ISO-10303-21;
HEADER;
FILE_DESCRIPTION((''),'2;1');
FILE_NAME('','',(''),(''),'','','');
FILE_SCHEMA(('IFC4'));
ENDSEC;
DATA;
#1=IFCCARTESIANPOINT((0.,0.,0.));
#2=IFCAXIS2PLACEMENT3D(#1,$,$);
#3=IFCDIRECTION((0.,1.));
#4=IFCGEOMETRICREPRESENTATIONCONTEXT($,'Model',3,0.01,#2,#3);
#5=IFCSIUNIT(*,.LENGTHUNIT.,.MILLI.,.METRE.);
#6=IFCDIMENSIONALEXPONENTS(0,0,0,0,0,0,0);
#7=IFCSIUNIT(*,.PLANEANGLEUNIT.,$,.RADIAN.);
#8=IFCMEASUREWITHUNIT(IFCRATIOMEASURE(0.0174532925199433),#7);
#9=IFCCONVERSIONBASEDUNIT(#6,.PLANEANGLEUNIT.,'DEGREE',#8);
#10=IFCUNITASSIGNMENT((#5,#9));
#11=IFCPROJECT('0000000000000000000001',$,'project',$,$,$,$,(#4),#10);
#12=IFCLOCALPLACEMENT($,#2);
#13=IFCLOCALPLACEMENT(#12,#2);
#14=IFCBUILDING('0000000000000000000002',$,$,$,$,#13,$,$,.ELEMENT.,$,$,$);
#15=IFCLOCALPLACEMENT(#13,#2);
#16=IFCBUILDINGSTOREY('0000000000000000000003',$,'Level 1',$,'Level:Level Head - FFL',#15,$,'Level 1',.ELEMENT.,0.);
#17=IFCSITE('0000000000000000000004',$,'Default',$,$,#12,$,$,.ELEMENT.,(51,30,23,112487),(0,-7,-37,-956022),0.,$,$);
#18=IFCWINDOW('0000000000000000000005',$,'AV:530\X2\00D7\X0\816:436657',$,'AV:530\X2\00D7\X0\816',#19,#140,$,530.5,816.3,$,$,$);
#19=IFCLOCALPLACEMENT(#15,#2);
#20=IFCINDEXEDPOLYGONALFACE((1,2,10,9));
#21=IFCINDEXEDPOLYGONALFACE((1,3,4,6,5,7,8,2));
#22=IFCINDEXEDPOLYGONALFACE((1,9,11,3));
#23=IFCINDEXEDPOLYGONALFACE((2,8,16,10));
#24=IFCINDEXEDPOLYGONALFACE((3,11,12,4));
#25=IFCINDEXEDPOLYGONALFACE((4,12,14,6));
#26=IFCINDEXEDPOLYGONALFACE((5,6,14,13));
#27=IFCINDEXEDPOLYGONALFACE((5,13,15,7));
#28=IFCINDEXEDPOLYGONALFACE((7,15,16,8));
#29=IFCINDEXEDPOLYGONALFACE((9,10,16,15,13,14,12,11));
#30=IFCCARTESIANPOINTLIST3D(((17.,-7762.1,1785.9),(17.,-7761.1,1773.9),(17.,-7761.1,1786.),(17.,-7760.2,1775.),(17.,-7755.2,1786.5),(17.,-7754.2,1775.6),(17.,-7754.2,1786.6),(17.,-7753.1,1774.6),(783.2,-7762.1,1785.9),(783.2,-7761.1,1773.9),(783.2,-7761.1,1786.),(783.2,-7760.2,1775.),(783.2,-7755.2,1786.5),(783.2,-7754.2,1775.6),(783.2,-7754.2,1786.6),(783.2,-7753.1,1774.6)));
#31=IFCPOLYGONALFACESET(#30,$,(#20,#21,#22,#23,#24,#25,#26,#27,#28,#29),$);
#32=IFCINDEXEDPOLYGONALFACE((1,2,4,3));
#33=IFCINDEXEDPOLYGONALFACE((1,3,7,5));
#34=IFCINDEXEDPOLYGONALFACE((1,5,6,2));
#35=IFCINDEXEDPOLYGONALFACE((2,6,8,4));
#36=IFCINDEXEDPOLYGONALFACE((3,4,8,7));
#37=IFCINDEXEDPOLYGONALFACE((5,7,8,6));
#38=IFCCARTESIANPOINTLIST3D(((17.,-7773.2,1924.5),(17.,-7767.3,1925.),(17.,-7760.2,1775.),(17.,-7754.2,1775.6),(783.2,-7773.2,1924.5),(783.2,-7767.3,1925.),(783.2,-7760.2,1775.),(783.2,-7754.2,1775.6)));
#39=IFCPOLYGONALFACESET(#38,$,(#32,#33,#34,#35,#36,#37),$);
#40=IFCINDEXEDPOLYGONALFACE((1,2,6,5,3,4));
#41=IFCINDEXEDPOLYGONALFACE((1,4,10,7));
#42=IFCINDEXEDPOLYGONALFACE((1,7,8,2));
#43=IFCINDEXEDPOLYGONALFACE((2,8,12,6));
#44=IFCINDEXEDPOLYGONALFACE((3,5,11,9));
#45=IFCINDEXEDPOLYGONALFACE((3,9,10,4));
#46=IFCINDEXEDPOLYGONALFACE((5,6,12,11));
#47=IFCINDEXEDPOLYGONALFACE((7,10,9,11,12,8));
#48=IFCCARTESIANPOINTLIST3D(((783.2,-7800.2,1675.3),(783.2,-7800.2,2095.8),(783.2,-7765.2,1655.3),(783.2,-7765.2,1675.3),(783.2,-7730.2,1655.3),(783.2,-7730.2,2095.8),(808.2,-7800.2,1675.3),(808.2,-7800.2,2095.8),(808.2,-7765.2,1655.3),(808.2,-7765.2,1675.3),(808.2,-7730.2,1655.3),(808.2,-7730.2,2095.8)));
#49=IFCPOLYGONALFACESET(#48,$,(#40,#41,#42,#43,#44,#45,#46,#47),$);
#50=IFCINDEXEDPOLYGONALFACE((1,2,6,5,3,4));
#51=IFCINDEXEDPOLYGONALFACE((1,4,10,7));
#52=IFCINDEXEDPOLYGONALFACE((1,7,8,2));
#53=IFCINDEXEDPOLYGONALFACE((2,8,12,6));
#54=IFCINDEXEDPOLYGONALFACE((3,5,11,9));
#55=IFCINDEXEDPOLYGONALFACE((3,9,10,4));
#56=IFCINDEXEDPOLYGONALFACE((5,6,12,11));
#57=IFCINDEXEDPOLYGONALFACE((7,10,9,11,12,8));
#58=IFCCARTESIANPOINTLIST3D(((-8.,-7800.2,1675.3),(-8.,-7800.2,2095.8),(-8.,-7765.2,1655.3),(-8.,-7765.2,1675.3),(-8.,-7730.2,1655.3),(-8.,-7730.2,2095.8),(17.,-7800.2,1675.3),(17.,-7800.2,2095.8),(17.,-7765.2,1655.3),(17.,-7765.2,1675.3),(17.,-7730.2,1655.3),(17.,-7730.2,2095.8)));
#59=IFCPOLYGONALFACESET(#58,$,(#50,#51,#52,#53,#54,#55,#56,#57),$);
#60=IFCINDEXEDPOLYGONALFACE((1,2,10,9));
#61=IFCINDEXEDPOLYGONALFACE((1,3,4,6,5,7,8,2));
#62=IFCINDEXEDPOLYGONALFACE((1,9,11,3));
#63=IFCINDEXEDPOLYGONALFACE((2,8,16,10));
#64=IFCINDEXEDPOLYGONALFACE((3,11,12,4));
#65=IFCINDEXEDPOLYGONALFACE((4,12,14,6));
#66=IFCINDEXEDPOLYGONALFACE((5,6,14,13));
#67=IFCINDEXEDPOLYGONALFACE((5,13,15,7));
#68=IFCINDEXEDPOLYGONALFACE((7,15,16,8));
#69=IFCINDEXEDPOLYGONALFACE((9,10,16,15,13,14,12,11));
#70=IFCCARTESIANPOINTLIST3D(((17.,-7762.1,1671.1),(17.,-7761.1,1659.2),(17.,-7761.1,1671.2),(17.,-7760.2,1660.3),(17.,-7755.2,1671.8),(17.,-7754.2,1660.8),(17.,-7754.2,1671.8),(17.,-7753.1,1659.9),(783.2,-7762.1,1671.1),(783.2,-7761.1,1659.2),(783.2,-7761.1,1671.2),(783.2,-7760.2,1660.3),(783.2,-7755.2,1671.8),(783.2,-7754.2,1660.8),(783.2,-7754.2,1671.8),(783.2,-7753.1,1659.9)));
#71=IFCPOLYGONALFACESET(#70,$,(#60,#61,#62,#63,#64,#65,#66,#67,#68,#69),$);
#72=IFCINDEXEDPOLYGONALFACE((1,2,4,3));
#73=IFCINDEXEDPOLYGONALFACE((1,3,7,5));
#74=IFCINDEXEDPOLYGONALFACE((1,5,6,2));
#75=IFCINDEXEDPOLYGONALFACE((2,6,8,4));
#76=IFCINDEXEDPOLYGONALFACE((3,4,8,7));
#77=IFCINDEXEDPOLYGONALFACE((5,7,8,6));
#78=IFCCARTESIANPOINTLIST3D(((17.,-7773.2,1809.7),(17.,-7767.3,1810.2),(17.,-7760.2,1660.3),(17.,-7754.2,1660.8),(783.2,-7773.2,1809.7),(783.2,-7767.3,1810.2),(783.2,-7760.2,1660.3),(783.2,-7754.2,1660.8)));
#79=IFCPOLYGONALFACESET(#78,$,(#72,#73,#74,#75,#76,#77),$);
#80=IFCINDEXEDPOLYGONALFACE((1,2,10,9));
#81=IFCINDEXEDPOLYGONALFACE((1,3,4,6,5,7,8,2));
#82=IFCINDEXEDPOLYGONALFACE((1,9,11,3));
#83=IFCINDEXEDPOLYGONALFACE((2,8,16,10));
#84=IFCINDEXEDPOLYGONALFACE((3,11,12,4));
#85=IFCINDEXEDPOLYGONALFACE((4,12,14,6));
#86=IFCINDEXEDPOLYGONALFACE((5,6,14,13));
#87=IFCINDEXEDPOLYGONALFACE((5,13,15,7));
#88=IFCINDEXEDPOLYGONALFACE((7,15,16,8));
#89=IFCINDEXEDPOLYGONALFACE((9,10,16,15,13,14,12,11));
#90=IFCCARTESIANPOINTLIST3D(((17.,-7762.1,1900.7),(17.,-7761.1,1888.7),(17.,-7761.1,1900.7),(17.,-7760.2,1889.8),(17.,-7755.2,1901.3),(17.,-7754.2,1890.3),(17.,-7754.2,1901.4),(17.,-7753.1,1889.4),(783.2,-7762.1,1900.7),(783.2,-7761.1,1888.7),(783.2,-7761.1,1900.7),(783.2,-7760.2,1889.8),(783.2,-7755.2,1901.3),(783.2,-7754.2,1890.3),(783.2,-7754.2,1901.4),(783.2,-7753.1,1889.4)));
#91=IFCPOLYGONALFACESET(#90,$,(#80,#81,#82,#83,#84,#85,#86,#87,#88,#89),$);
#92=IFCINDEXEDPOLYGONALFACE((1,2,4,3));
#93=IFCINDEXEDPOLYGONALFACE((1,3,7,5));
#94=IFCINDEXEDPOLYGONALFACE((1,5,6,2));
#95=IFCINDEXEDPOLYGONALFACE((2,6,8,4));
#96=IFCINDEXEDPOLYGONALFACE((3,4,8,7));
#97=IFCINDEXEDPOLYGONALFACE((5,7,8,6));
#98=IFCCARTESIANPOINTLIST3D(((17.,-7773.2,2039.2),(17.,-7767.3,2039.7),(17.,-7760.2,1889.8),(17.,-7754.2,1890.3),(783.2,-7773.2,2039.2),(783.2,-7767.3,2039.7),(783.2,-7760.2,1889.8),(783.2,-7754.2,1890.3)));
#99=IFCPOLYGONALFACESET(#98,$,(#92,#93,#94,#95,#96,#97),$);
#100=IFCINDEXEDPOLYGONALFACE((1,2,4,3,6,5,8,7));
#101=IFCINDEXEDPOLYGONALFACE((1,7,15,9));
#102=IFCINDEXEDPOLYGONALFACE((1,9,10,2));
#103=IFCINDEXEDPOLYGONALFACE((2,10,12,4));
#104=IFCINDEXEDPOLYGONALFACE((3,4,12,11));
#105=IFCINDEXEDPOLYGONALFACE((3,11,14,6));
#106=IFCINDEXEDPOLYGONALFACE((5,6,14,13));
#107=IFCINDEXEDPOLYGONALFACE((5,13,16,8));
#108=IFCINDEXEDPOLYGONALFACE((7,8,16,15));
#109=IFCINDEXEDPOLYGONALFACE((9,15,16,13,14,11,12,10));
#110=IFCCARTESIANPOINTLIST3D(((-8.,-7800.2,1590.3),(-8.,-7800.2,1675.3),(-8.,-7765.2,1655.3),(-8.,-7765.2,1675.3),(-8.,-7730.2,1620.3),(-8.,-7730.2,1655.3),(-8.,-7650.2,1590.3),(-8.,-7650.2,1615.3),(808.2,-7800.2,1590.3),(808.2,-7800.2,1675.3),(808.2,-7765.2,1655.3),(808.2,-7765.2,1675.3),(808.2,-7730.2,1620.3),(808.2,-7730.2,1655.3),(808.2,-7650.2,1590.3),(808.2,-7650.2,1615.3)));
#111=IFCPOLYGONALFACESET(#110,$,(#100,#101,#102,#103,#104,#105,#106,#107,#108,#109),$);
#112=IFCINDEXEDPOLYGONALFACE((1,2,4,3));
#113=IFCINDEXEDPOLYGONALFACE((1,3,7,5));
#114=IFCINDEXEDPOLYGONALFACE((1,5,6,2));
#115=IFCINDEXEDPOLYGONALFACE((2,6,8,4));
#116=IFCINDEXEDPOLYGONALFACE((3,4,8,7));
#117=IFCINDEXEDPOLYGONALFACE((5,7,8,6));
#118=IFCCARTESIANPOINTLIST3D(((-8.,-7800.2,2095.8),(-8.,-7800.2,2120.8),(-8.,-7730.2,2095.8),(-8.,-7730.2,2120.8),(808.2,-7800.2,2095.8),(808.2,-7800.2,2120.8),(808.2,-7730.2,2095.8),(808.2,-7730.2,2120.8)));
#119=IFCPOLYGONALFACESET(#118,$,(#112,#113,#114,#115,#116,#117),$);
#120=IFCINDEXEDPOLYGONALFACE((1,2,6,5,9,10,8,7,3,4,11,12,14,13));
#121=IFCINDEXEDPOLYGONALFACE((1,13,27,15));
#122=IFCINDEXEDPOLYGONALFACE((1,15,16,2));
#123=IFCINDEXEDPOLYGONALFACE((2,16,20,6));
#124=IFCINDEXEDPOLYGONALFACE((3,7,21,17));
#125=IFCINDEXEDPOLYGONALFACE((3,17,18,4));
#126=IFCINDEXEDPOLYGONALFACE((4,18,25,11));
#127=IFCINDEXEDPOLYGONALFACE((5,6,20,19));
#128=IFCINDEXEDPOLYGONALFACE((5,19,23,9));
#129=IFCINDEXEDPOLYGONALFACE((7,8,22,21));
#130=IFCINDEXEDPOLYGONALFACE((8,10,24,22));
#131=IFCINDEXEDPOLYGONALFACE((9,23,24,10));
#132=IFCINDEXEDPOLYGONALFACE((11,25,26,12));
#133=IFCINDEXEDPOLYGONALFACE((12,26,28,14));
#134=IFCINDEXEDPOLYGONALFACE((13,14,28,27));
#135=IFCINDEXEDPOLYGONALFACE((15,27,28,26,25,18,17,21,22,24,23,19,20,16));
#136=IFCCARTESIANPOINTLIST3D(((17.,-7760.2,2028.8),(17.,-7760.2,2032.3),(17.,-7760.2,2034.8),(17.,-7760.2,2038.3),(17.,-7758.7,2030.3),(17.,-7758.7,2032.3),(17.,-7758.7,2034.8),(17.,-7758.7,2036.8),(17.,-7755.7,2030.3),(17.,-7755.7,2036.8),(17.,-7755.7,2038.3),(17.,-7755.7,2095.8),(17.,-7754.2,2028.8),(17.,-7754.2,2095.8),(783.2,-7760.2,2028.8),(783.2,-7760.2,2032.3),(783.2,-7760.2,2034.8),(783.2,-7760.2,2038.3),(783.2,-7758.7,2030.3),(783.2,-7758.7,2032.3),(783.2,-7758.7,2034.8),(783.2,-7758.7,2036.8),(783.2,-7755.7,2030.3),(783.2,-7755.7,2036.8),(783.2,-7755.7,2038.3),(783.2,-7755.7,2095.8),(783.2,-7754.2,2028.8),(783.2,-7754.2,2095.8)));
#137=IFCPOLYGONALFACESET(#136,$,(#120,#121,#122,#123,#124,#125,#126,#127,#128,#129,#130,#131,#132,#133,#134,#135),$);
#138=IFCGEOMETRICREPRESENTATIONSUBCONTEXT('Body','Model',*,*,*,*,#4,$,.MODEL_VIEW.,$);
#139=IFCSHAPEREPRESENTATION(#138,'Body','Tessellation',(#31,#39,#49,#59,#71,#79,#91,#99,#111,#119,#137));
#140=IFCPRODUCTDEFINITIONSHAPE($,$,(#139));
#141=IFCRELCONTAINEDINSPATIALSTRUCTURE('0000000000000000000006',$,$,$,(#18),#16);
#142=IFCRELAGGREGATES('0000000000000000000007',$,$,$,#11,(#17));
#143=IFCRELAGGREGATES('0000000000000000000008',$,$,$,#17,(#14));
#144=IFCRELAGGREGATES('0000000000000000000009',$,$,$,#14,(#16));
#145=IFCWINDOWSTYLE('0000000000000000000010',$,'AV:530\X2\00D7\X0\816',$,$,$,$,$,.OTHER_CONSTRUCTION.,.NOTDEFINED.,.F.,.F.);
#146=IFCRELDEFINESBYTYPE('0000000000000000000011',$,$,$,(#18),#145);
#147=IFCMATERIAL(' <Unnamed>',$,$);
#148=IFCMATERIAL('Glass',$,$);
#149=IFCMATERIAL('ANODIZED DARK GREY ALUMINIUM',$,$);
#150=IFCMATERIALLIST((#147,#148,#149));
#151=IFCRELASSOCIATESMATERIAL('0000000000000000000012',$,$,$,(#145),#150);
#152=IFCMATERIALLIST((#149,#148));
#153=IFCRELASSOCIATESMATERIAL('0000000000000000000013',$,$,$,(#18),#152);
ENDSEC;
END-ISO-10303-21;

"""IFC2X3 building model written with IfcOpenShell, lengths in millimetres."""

from ifc_helpers import new_model, entity, si_unit, converted_unit, direction, frame, frame_2d, origin, origin_2d_with_axis, place, context, subcontext, project, spatial, polyline, rectangle, outline, extrude, source, transform, mapped, material, material_list, type_object, type_shapes, element, save


model = new_model("IFC2X3")

# Units and contexts
model_context = context("Model", 3, precision=0.01, world=origin(), true_north=direction((0.0, 1.0)))
body_context = subcontext(model_context, "Body", "Model", "MODEL_VIEW")
ifc_project = project(units=[si_unit("LENGTHUNIT", "METRE", prefix="MILLI"), converted_unit("PLANEANGLEUNIT", "DEGREE", entity("IfcRatioMeasure", 0.0174532925199433), si_unit("PLANEANGLEUNIT", "RADIAN"), dimensions=[0, 0, 0, 0, 0, 0, 0])], contexts=[model_context])

# Site, building, storey
site_placement = place(None, origin())
site = spatial("IfcSite", under=ifc_project, at=site_placement, Name="Default", CompositionType="ELEMENT", RefLatitude=(51, 30, 23, 112487), RefLongitude=(0, -7, -37, -956022), RefElevation=0.0)
building_placement = place(site_placement, origin())
building = spatial("IfcBuilding", under=site, at=building_placement, CompositionType="ELEMENT")
storey_placement = place(building_placement, origin())
storey = spatial("IfcBuildingStorey", under=building, at=storey_placement, Name="Level 1", ObjectType="Level:Level Head - FFL", LongName="Level 1", CompositionType="ELEMENT", Elevation=0.0)

# Window
ifc_material_1 = material(Name="Glass")
ifc_material_2 = material(Name="ANODIZED DARK GREY ALUMINIUM")
ifc_material_list_1 = material_list([ifc_material_2, ifc_material_1])
ifc_material_3 = material(Name=" <Unnamed>")
ifc_material_list_2 = material_list([ifc_material_3, ifc_material_1, ifc_material_2])
window_style_1 = type_object("IfcWindowStyle", Name="AV:530×816", ConstructionType="OTHER_CONSTRUCTION", OperationType="NOTDEFINED", ParameterTakesPrecedence=False, Sizeable=False, material=ifc_material_list_2)
shared_shape_1 = source(origin(), body_context, "Body", "SweptSolid", [
    extrude(outline(polyline([(-5.8, -3.0), (-5.8, -4.0), (6.3, -4.0), (6.3, 4.0), (-5.8, 4.0), (-5.8, 3.0), (5.2, 3.0), (5.2, -3.0), (-5.8, -3.0)])), frame((25.0, 42.5, 190.2), z_axis=(-1.0, 0.0, 0.0), x_axis=(0.0, 0.087156, -0.996195)), (0.0, 0.0, -1.0), 766.3),
    extrude(rectangle(XDim=150.0, YDim=6.0, at=frame_2d((0.0, 0.0), x_axis=(1.0, 0.0))), frame((25.0, 36.5, 259.7), z_axis=(1.0, 0.0, 0.0), x_axis=(0.0, 0.087156, -0.996195)), (0.0, 0.0, 1.0), 766.3),
    extrude(outline(polyline([(-287.0, -35.0), (133.5, -35.0), (133.5, 0.0), (153.5, 0.0), (153.5, 35.0), (-287.0, 35.0), (-287.0, -35.0)])), frame((791.3, 35.0, 218.5), z_axis=(1.0, 0.0, 0.0), x_axis=(0.0, 0.0, -1.0)), (0.0, 0.0, 1.0), 25.0),
    extrude(outline(polyline([(-287.0, -35.0), (133.5, -35.0), (133.5, 0.0), (153.5, 0.0), (153.5, 35.0), (-287.0, 35.0), (-287.0, -35.0)])), frame((0.0, 35.0, 218.5), z_axis=(1.0, 0.0, 0.0), x_axis=(0.0, 0.0, -1.0)), (0.0, 0.0, 1.0), 25.0),
    extrude(outline(polyline([(-5.8, -3.0), (-5.8, -4.0), (6.3, -4.0), (6.3, 4.0), (-5.8, 4.0), (-5.8, 3.0), (5.2, 3.0), (5.2, -3.0), (-5.8, -3.0)])), frame((25.0, 42.5, 75.5), z_axis=(-1.0, 0.0, 0.0), x_axis=(0.0, 0.087156, -0.996195)), (0.0, 0.0, -1.0), 766.3),
    extrude(rectangle(XDim=150.0, YDim=6.0, at=frame_2d((0.0, 0.0), x_axis=(1.0, 0.0))), frame((25.0, 36.5, 145.0), z_axis=(1.0, 0.0, 0.0), x_axis=(0.0, 0.087156, -0.996195)), (0.0, 0.0, 1.0), 766.3),
    extrude(outline(polyline([(-5.8, -3.0), (-5.8, -4.0), (6.3, -4.0), (6.3, 4.0), (-5.8, 4.0), (-5.8, 3.0), (5.2, 3.0), (5.2, -3.0), (-5.8, -3.0)])), frame((25.0, 42.5, 305.0), z_axis=(-1.0, 0.0, 0.0), x_axis=(0.0, 0.087156, -0.996195)), (0.0, 0.0, -1.0), 766.3),
    extrude(rectangle(XDim=150.0, YDim=6.0, at=frame_2d((0.0, 0.0), x_axis=(1.0, 0.0))), frame((25.0, 36.5, 374.5), z_axis=(1.0, 0.0, 0.0), x_axis=(0.0, 0.087156, -0.996195)), (0.0, 0.0, 1.0), 766.3),
    extrude(outline(polyline([(-63.8, -44.4), (86.3, -44.4), (86.3, -19.4), (6.2, -14.4), (6.2, 20.6), (-28.8, 20.6), (-28.8, 40.6), (-63.8, 40.6), (-63.8, -44.4)])), frame((0.0, 63.8, 44.4), z_axis=(1.0, 0.0, 0.0), x_axis=(0.0, 1.0, 0.0)), (0.0, 0.0, 1.0), 816.3),
    extrude(rectangle(XDim=70.0, YDim=816.3, at=origin_2d_with_axis()), frame((408.1, 35.0, 505.5), z_axis=(0.0, 0.0, 1.0), x_axis=(0.0, -1.0, 0.0)), (0.0, 0.0, 1.0), 25.0),
    extrude(outline(polyline([(-3.4, -53.4), (-1.9, -53.4), (-1.9, 4.1), (2.6, 4.1), (2.6, 7.6), (1.1, 7.6), (1.1, 5.6), (-1.9, 5.6), (-1.9, 12.1), (1.1, 12.1), (1.1, 10.1), (2.6, 10.1), (2.6, 13.6), (-3.4, 13.6), (-3.4, -53.4)])), frame((25.0, 42.6, 452.1), z_axis=(1.0, 0.0, 0.0), x_axis=(0.0, -1.0, 0.0)), (0.0, 0.0, 1.0), 766.3),
])
type_shapes(window_style_1, [shared_shape_1])
window_1_placement = place(storey_placement, frame((-8.0, -7800.2, 1590.3)))
element("IfcWindow", 1, at=window_1_placement, inside=storey, type_object=window_style_1, material=ifc_material_list_1, Name="AV:530×816:436657", ObjectType="AV:530×816", OverallHeight=530.5, OverallWidth=816.3, context=body_context, shape_type="MappedRepresentation", body=[
    mapped(shared_shape_1, transform((0.0, 0.0, 0.0), scale=1.0)),
])

save(model, "model.ifc")
